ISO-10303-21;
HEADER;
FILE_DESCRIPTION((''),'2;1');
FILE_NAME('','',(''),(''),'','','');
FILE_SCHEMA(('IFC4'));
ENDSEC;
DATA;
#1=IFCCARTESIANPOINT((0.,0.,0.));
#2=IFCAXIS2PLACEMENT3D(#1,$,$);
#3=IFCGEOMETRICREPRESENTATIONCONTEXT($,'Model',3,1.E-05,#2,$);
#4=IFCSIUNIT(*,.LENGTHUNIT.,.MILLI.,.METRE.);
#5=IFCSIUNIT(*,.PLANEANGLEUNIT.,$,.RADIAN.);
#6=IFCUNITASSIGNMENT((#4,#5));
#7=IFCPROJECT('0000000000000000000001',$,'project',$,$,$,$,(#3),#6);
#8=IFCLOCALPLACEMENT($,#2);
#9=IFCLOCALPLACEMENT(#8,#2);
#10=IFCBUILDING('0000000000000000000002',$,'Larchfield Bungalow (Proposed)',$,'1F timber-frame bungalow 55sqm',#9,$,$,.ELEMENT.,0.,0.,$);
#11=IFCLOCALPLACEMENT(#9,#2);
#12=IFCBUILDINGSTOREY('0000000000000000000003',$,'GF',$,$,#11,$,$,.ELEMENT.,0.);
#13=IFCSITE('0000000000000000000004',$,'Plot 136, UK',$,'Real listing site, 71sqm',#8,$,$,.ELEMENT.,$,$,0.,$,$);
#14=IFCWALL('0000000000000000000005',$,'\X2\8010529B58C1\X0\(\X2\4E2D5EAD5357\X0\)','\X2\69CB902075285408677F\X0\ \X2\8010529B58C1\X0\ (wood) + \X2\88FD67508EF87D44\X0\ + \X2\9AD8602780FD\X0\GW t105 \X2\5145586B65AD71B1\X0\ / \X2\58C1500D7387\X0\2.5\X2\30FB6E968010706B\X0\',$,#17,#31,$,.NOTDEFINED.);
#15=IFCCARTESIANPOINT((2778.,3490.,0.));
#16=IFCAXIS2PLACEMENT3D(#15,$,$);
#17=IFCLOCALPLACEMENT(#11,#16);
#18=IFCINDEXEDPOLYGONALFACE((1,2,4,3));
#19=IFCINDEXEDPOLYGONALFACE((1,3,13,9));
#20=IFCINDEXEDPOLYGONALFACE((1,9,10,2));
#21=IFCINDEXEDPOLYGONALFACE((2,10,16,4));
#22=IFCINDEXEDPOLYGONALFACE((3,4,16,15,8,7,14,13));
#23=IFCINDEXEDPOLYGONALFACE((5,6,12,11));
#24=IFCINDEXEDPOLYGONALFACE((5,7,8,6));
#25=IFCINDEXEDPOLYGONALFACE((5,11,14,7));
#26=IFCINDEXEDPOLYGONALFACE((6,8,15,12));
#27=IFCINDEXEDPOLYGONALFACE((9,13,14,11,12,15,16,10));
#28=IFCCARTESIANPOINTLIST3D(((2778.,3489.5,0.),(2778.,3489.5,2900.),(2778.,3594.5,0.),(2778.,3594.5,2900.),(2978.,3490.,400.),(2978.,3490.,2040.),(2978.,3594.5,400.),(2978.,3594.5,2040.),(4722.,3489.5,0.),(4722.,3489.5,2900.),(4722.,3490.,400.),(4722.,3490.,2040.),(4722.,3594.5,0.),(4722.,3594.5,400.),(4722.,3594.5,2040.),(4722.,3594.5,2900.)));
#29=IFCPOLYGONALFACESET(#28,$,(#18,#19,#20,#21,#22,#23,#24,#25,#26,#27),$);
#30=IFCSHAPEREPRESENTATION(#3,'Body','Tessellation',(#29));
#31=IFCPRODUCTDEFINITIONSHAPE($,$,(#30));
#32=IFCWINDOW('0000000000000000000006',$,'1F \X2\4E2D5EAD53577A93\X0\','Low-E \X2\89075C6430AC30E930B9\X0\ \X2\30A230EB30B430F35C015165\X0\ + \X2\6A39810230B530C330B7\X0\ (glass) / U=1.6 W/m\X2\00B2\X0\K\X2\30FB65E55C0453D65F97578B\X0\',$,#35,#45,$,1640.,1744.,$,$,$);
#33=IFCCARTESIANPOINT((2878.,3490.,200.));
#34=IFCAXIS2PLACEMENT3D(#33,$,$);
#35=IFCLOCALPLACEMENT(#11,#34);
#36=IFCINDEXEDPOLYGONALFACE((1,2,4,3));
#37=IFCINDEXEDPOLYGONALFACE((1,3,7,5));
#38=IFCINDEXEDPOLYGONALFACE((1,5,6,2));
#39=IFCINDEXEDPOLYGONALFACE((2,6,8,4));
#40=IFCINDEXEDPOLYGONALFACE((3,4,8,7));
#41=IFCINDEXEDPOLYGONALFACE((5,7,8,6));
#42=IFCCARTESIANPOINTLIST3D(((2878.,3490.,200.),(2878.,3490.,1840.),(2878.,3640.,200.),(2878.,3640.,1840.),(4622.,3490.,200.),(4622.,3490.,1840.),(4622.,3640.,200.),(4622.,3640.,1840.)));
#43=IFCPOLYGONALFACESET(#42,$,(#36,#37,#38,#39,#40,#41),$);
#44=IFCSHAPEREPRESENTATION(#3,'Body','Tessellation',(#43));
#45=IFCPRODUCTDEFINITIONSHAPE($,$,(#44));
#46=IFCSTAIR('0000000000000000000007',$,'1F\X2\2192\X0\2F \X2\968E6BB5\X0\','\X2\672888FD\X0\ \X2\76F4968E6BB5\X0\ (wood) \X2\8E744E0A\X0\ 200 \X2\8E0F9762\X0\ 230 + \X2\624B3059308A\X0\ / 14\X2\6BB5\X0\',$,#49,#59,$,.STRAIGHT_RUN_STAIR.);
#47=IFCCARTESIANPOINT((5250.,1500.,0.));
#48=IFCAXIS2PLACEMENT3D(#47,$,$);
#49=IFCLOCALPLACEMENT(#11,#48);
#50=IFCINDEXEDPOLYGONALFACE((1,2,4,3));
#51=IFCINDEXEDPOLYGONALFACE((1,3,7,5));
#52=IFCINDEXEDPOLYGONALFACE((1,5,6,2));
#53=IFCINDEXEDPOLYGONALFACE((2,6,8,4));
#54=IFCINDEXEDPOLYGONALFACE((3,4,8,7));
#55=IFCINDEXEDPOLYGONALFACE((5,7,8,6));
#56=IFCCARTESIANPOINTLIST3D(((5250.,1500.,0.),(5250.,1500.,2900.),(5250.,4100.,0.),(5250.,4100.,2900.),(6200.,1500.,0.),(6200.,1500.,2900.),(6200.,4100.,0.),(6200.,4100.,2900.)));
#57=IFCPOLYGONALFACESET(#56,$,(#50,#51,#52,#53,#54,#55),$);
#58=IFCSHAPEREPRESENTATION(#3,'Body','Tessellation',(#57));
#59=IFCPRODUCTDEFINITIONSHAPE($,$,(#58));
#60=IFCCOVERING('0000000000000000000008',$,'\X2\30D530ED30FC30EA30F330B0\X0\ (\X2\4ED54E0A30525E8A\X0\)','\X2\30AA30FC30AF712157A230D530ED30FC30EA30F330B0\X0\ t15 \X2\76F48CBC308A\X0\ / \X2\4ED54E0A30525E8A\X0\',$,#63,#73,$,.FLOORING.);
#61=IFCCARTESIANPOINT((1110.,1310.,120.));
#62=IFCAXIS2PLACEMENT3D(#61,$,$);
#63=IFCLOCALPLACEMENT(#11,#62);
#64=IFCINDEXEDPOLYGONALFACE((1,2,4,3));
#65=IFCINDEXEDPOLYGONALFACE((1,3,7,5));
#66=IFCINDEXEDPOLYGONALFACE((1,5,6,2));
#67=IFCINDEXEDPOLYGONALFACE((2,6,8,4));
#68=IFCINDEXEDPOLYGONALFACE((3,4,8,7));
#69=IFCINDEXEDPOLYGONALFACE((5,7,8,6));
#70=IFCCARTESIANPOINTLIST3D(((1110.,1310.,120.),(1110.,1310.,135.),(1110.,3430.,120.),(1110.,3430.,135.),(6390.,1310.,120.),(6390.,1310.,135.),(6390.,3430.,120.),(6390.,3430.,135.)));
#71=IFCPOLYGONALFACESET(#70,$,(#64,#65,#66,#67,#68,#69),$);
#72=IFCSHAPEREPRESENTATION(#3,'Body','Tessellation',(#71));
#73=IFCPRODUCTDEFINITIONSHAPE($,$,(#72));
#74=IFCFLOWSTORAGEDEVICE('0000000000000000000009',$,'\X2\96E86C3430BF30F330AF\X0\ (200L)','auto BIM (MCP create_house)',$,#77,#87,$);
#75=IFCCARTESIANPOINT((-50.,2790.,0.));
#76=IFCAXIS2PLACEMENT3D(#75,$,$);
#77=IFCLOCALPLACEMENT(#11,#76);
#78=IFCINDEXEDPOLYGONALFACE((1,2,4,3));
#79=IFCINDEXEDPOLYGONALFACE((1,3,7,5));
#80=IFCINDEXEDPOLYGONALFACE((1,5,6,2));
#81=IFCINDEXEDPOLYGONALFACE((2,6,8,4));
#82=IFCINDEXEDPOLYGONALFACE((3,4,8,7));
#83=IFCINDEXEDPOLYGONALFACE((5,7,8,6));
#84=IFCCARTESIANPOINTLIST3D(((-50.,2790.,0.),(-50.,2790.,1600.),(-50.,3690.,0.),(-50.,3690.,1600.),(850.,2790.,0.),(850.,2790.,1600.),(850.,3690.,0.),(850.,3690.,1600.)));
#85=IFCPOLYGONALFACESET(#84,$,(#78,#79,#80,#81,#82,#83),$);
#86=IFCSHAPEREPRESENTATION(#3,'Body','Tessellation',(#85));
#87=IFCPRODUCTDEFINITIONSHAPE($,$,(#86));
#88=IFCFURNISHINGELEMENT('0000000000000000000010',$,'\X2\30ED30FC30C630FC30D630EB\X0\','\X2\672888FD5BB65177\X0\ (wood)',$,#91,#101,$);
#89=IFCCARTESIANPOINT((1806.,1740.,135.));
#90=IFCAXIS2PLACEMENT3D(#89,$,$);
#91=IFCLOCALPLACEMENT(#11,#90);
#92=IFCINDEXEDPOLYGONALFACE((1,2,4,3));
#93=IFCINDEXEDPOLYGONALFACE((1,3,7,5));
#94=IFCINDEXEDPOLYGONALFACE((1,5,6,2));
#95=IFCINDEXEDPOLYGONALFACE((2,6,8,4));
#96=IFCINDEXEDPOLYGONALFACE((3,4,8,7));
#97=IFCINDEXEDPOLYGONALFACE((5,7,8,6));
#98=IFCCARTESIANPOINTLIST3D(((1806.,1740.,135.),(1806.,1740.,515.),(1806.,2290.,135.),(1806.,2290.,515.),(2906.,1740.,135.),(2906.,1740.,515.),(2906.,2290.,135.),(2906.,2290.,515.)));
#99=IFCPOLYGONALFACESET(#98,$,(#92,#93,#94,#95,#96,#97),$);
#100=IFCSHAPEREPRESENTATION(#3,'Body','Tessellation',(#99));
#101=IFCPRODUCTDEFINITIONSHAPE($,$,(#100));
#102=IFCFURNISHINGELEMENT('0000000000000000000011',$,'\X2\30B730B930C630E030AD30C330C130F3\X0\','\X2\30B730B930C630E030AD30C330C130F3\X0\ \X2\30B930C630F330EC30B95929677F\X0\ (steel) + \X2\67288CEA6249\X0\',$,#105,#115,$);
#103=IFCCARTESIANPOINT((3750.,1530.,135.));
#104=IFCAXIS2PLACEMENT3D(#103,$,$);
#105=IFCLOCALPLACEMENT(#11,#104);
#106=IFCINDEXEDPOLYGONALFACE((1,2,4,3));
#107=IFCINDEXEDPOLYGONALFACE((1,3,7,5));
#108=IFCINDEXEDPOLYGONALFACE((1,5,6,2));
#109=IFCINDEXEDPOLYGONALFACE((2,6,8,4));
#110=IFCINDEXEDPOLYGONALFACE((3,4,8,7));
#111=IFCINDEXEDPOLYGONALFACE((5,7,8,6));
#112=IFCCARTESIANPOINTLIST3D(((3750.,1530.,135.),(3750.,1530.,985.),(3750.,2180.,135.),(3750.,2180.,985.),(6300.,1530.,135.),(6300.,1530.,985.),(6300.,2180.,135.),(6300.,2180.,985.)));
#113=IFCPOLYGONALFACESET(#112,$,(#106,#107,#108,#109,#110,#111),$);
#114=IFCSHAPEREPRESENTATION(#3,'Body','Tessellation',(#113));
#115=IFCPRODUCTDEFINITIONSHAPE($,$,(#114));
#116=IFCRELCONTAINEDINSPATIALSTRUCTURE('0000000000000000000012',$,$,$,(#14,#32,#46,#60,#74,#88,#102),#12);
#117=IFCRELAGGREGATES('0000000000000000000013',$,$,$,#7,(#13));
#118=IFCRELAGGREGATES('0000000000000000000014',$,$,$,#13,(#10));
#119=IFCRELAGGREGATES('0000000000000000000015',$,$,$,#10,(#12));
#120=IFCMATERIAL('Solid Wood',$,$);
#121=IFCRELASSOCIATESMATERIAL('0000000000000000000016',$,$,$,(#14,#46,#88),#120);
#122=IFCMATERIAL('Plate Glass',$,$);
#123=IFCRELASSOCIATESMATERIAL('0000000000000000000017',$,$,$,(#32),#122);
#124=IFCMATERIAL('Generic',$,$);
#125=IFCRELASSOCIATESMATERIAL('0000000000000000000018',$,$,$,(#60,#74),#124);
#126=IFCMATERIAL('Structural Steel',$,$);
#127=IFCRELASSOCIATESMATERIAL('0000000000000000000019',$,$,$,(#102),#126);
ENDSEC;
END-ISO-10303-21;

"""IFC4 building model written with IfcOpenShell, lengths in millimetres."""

from ifc_helpers import new_model, si_unit, frame, frame_2d, origin, place, context, project, spatial, rectangle, extrude, material, element, fill, save


model = new_model("IFC4")

# Units and contexts
model_context = context("Model", 3, precision=1e-05, world=origin())
ifc_project = project(units=[si_unit("LENGTHUNIT", "METRE", prefix="MILLI"), si_unit("PLANEANGLEUNIT", "RADIAN")], contexts=[model_context])

# Site, building, storey
site_placement = place(None, origin())
site = spatial("IfcSite", under=ifc_project, at=site_placement, Name="Plot 136, UK", ObjectType="Real listing site, 71sqm", CompositionType="ELEMENT", RefElevation=0.0)
building_placement = place(site_placement, origin())
building = spatial("IfcBuilding", under=site, at=building_placement, Name="Larchfield Bungalow (Proposed)", ObjectType="1F timber-frame bungalow 55sqm", CompositionType="ELEMENT", ElevationOfRefHeight=0.0, ElevationOfTerrain=0.0)
storey_placement = place(building_placement, origin())
storey = spatial("IfcBuildingStorey", under=building, at=storey_placement, Name="GF", CompositionType="ELEMENT", Elevation=0.0)

# Shared definitions
ifc_material_1 = material(Name="Solid Wood")

# Shared definitions
ifc_material_2 = material(Name="Plate Glass")

# Wall, opening, window
wall_1_placement = place(storey_placement, frame((2778.0, 3490.0, 0.0)))
wall_1 = element("IfcWall", 1, at=wall_1_placement, inside=storey, material=ifc_material_1, Name="耐力壁(中庭南)", Description="構造用合板 耐力壁 (wood) + 製材軸組 + 高性能GW t105 充填断熱 / 壁倍率2.5・準耐火", PredefinedType="NOTDEFINED", context=model_context, shape_type="SweptSolid", body=[
    extrude(rectangle(XDim=1944.0, YDim=105.0, at=frame_2d((972.0, 52.0))), frame((2778.0, 3490.0, 0.0)), (0.0, 0.0, 1.0), 2900.0),
])
opening_1_placement = place(storey_placement, frame((2878.0, 3490.0, 200.0)))
opening_1 = element("IfcOpeningElement", 2, at=opening_1_placement, cuts=wall_1, PredefinedType="NOTDEFINED", context=model_context, shape_type="SweptSolid", body=[
    extrude(rectangle(XDim=1744.0, YDim=150.0, at=frame_2d((872.0, 75.0))), frame((2878.0, 3490.0, 200.0)), (0.0, 0.0, 1.0), 1640.0),
])
window_1_placement = place(storey_placement, frame((2878.0, 3490.0, 200.0)))
window_1 = element("IfcWindow", 3, at=window_1_placement, inside=storey, material=ifc_material_2, Name="1F 中庭南窓", Description="Low-E 複層ガラス アルゴン封入 + 樹脂サッシ (glass) / U=1.6 W/m²K・日射取得型", OverallHeight=1640.0, OverallWidth=1744.0, context=model_context, shape_type="SweptSolid", body=[
    extrude(rectangle(XDim=1744.0, YDim=150.0, at=frame_2d((872.0, 75.0))), frame((2878.0, 3490.0, 200.0)), (0.0, 0.0, 1.0), 1640.0),
])
fill(opening_1, window_1)

# Stair
stair_placement = place(storey_placement, frame((5250.0, 1500.0, 0.0)))
element("IfcStair", 4, at=stair_placement, inside=storey, material=ifc_material_1, Name="1F→2F 階段", Description="木製 直階段 (wood) 蹴上 200 踏面 230 + 手すり / 14段", PredefinedType="STRAIGHT_RUN_STAIR", context=model_context, shape_type="SweptSolid", body=[
    extrude(rectangle(XDim=950.0, YDim=2600.0, at=frame_2d((475.0, 1300.0))), frame((5250.0, 1500.0, 0.0)), (0.0, 0.0, 1.0), 2900.0),
])

# Covering
ifc_material_3 = material(Name="Generic")
covering_placement = place(storey_placement, frame((1110.0, 1310.0, 120.0)))
element("IfcCovering", 5, at=covering_placement, inside=storey, material=ifc_material_3, Name="フローリング (仕上げ床)", Description="オーク無垢フローリング t15 直貼り / 仕上げ床", PredefinedType="FLOORING", context=model_context, shape_type="SweptSolid", body=[
    extrude(rectangle(XDim=5280.0, YDim=2120.0, at=frame_2d((2640.0, 1060.0))), frame((1110.0, 1310.0, 120.0)), (0.0, 0.0, 1.0), 15.0),
])

# Flow storage device
flow_storage_device_placement = place(storey_placement, frame((-50.0, 2790.0, 0.0)))
element("IfcFlowStorageDevice", 6, at=flow_storage_device_placement, inside=storey, material=ifc_material_3, Name="雨水タンク (200L)", Description="auto BIM (MCP create_house)", context=model_context, shape_type="SweptSolid", body=[
    extrude(rectangle(XDim=900.0, YDim=900.0, at=frame_2d((450.0, 450.0))), frame((-50.0, 2790.0, 0.0)), (0.0, 0.0, 1.0), 1600.0),
])

# Furnishing elements
furnishing_1_placement = place(storey_placement, frame((1806.0, 1740.0, 135.0)))
element("IfcFurnishingElement", 7, at=furnishing_1_placement, inside=storey, material=ifc_material_1, Name="ローテーブル", Description="木製家具 (wood)", context=model_context, shape_type="SweptSolid", body=[
    extrude(rectangle(XDim=1100.0, YDim=550.0, at=frame_2d((550.0, 275.0))), frame((1806.0, 1740.0, 135.0)), (0.0, 0.0, 1.0), 380.0),
])
ifc_material_4 = material(Name="Structural Steel")
furnishing_2_placement = place(storey_placement, frame((3750.0, 1530.0, 135.0)))
element("IfcFurnishingElement", 8, at=furnishing_2_placement, inside=storey, material=ifc_material_4, Name="システムキッチン", Description="システムキッチン ステンレス天板 (steel) + 木質扉", context=model_context, shape_type="SweptSolid", body=[
    extrude(rectangle(XDim=2550.0, YDim=650.0, at=frame_2d((1275.0, 325.0))), frame((3750.0, 1530.0, 135.0)), (0.0, 0.0, 1.0), 850.0),
])

save(model, "model.ifc")
